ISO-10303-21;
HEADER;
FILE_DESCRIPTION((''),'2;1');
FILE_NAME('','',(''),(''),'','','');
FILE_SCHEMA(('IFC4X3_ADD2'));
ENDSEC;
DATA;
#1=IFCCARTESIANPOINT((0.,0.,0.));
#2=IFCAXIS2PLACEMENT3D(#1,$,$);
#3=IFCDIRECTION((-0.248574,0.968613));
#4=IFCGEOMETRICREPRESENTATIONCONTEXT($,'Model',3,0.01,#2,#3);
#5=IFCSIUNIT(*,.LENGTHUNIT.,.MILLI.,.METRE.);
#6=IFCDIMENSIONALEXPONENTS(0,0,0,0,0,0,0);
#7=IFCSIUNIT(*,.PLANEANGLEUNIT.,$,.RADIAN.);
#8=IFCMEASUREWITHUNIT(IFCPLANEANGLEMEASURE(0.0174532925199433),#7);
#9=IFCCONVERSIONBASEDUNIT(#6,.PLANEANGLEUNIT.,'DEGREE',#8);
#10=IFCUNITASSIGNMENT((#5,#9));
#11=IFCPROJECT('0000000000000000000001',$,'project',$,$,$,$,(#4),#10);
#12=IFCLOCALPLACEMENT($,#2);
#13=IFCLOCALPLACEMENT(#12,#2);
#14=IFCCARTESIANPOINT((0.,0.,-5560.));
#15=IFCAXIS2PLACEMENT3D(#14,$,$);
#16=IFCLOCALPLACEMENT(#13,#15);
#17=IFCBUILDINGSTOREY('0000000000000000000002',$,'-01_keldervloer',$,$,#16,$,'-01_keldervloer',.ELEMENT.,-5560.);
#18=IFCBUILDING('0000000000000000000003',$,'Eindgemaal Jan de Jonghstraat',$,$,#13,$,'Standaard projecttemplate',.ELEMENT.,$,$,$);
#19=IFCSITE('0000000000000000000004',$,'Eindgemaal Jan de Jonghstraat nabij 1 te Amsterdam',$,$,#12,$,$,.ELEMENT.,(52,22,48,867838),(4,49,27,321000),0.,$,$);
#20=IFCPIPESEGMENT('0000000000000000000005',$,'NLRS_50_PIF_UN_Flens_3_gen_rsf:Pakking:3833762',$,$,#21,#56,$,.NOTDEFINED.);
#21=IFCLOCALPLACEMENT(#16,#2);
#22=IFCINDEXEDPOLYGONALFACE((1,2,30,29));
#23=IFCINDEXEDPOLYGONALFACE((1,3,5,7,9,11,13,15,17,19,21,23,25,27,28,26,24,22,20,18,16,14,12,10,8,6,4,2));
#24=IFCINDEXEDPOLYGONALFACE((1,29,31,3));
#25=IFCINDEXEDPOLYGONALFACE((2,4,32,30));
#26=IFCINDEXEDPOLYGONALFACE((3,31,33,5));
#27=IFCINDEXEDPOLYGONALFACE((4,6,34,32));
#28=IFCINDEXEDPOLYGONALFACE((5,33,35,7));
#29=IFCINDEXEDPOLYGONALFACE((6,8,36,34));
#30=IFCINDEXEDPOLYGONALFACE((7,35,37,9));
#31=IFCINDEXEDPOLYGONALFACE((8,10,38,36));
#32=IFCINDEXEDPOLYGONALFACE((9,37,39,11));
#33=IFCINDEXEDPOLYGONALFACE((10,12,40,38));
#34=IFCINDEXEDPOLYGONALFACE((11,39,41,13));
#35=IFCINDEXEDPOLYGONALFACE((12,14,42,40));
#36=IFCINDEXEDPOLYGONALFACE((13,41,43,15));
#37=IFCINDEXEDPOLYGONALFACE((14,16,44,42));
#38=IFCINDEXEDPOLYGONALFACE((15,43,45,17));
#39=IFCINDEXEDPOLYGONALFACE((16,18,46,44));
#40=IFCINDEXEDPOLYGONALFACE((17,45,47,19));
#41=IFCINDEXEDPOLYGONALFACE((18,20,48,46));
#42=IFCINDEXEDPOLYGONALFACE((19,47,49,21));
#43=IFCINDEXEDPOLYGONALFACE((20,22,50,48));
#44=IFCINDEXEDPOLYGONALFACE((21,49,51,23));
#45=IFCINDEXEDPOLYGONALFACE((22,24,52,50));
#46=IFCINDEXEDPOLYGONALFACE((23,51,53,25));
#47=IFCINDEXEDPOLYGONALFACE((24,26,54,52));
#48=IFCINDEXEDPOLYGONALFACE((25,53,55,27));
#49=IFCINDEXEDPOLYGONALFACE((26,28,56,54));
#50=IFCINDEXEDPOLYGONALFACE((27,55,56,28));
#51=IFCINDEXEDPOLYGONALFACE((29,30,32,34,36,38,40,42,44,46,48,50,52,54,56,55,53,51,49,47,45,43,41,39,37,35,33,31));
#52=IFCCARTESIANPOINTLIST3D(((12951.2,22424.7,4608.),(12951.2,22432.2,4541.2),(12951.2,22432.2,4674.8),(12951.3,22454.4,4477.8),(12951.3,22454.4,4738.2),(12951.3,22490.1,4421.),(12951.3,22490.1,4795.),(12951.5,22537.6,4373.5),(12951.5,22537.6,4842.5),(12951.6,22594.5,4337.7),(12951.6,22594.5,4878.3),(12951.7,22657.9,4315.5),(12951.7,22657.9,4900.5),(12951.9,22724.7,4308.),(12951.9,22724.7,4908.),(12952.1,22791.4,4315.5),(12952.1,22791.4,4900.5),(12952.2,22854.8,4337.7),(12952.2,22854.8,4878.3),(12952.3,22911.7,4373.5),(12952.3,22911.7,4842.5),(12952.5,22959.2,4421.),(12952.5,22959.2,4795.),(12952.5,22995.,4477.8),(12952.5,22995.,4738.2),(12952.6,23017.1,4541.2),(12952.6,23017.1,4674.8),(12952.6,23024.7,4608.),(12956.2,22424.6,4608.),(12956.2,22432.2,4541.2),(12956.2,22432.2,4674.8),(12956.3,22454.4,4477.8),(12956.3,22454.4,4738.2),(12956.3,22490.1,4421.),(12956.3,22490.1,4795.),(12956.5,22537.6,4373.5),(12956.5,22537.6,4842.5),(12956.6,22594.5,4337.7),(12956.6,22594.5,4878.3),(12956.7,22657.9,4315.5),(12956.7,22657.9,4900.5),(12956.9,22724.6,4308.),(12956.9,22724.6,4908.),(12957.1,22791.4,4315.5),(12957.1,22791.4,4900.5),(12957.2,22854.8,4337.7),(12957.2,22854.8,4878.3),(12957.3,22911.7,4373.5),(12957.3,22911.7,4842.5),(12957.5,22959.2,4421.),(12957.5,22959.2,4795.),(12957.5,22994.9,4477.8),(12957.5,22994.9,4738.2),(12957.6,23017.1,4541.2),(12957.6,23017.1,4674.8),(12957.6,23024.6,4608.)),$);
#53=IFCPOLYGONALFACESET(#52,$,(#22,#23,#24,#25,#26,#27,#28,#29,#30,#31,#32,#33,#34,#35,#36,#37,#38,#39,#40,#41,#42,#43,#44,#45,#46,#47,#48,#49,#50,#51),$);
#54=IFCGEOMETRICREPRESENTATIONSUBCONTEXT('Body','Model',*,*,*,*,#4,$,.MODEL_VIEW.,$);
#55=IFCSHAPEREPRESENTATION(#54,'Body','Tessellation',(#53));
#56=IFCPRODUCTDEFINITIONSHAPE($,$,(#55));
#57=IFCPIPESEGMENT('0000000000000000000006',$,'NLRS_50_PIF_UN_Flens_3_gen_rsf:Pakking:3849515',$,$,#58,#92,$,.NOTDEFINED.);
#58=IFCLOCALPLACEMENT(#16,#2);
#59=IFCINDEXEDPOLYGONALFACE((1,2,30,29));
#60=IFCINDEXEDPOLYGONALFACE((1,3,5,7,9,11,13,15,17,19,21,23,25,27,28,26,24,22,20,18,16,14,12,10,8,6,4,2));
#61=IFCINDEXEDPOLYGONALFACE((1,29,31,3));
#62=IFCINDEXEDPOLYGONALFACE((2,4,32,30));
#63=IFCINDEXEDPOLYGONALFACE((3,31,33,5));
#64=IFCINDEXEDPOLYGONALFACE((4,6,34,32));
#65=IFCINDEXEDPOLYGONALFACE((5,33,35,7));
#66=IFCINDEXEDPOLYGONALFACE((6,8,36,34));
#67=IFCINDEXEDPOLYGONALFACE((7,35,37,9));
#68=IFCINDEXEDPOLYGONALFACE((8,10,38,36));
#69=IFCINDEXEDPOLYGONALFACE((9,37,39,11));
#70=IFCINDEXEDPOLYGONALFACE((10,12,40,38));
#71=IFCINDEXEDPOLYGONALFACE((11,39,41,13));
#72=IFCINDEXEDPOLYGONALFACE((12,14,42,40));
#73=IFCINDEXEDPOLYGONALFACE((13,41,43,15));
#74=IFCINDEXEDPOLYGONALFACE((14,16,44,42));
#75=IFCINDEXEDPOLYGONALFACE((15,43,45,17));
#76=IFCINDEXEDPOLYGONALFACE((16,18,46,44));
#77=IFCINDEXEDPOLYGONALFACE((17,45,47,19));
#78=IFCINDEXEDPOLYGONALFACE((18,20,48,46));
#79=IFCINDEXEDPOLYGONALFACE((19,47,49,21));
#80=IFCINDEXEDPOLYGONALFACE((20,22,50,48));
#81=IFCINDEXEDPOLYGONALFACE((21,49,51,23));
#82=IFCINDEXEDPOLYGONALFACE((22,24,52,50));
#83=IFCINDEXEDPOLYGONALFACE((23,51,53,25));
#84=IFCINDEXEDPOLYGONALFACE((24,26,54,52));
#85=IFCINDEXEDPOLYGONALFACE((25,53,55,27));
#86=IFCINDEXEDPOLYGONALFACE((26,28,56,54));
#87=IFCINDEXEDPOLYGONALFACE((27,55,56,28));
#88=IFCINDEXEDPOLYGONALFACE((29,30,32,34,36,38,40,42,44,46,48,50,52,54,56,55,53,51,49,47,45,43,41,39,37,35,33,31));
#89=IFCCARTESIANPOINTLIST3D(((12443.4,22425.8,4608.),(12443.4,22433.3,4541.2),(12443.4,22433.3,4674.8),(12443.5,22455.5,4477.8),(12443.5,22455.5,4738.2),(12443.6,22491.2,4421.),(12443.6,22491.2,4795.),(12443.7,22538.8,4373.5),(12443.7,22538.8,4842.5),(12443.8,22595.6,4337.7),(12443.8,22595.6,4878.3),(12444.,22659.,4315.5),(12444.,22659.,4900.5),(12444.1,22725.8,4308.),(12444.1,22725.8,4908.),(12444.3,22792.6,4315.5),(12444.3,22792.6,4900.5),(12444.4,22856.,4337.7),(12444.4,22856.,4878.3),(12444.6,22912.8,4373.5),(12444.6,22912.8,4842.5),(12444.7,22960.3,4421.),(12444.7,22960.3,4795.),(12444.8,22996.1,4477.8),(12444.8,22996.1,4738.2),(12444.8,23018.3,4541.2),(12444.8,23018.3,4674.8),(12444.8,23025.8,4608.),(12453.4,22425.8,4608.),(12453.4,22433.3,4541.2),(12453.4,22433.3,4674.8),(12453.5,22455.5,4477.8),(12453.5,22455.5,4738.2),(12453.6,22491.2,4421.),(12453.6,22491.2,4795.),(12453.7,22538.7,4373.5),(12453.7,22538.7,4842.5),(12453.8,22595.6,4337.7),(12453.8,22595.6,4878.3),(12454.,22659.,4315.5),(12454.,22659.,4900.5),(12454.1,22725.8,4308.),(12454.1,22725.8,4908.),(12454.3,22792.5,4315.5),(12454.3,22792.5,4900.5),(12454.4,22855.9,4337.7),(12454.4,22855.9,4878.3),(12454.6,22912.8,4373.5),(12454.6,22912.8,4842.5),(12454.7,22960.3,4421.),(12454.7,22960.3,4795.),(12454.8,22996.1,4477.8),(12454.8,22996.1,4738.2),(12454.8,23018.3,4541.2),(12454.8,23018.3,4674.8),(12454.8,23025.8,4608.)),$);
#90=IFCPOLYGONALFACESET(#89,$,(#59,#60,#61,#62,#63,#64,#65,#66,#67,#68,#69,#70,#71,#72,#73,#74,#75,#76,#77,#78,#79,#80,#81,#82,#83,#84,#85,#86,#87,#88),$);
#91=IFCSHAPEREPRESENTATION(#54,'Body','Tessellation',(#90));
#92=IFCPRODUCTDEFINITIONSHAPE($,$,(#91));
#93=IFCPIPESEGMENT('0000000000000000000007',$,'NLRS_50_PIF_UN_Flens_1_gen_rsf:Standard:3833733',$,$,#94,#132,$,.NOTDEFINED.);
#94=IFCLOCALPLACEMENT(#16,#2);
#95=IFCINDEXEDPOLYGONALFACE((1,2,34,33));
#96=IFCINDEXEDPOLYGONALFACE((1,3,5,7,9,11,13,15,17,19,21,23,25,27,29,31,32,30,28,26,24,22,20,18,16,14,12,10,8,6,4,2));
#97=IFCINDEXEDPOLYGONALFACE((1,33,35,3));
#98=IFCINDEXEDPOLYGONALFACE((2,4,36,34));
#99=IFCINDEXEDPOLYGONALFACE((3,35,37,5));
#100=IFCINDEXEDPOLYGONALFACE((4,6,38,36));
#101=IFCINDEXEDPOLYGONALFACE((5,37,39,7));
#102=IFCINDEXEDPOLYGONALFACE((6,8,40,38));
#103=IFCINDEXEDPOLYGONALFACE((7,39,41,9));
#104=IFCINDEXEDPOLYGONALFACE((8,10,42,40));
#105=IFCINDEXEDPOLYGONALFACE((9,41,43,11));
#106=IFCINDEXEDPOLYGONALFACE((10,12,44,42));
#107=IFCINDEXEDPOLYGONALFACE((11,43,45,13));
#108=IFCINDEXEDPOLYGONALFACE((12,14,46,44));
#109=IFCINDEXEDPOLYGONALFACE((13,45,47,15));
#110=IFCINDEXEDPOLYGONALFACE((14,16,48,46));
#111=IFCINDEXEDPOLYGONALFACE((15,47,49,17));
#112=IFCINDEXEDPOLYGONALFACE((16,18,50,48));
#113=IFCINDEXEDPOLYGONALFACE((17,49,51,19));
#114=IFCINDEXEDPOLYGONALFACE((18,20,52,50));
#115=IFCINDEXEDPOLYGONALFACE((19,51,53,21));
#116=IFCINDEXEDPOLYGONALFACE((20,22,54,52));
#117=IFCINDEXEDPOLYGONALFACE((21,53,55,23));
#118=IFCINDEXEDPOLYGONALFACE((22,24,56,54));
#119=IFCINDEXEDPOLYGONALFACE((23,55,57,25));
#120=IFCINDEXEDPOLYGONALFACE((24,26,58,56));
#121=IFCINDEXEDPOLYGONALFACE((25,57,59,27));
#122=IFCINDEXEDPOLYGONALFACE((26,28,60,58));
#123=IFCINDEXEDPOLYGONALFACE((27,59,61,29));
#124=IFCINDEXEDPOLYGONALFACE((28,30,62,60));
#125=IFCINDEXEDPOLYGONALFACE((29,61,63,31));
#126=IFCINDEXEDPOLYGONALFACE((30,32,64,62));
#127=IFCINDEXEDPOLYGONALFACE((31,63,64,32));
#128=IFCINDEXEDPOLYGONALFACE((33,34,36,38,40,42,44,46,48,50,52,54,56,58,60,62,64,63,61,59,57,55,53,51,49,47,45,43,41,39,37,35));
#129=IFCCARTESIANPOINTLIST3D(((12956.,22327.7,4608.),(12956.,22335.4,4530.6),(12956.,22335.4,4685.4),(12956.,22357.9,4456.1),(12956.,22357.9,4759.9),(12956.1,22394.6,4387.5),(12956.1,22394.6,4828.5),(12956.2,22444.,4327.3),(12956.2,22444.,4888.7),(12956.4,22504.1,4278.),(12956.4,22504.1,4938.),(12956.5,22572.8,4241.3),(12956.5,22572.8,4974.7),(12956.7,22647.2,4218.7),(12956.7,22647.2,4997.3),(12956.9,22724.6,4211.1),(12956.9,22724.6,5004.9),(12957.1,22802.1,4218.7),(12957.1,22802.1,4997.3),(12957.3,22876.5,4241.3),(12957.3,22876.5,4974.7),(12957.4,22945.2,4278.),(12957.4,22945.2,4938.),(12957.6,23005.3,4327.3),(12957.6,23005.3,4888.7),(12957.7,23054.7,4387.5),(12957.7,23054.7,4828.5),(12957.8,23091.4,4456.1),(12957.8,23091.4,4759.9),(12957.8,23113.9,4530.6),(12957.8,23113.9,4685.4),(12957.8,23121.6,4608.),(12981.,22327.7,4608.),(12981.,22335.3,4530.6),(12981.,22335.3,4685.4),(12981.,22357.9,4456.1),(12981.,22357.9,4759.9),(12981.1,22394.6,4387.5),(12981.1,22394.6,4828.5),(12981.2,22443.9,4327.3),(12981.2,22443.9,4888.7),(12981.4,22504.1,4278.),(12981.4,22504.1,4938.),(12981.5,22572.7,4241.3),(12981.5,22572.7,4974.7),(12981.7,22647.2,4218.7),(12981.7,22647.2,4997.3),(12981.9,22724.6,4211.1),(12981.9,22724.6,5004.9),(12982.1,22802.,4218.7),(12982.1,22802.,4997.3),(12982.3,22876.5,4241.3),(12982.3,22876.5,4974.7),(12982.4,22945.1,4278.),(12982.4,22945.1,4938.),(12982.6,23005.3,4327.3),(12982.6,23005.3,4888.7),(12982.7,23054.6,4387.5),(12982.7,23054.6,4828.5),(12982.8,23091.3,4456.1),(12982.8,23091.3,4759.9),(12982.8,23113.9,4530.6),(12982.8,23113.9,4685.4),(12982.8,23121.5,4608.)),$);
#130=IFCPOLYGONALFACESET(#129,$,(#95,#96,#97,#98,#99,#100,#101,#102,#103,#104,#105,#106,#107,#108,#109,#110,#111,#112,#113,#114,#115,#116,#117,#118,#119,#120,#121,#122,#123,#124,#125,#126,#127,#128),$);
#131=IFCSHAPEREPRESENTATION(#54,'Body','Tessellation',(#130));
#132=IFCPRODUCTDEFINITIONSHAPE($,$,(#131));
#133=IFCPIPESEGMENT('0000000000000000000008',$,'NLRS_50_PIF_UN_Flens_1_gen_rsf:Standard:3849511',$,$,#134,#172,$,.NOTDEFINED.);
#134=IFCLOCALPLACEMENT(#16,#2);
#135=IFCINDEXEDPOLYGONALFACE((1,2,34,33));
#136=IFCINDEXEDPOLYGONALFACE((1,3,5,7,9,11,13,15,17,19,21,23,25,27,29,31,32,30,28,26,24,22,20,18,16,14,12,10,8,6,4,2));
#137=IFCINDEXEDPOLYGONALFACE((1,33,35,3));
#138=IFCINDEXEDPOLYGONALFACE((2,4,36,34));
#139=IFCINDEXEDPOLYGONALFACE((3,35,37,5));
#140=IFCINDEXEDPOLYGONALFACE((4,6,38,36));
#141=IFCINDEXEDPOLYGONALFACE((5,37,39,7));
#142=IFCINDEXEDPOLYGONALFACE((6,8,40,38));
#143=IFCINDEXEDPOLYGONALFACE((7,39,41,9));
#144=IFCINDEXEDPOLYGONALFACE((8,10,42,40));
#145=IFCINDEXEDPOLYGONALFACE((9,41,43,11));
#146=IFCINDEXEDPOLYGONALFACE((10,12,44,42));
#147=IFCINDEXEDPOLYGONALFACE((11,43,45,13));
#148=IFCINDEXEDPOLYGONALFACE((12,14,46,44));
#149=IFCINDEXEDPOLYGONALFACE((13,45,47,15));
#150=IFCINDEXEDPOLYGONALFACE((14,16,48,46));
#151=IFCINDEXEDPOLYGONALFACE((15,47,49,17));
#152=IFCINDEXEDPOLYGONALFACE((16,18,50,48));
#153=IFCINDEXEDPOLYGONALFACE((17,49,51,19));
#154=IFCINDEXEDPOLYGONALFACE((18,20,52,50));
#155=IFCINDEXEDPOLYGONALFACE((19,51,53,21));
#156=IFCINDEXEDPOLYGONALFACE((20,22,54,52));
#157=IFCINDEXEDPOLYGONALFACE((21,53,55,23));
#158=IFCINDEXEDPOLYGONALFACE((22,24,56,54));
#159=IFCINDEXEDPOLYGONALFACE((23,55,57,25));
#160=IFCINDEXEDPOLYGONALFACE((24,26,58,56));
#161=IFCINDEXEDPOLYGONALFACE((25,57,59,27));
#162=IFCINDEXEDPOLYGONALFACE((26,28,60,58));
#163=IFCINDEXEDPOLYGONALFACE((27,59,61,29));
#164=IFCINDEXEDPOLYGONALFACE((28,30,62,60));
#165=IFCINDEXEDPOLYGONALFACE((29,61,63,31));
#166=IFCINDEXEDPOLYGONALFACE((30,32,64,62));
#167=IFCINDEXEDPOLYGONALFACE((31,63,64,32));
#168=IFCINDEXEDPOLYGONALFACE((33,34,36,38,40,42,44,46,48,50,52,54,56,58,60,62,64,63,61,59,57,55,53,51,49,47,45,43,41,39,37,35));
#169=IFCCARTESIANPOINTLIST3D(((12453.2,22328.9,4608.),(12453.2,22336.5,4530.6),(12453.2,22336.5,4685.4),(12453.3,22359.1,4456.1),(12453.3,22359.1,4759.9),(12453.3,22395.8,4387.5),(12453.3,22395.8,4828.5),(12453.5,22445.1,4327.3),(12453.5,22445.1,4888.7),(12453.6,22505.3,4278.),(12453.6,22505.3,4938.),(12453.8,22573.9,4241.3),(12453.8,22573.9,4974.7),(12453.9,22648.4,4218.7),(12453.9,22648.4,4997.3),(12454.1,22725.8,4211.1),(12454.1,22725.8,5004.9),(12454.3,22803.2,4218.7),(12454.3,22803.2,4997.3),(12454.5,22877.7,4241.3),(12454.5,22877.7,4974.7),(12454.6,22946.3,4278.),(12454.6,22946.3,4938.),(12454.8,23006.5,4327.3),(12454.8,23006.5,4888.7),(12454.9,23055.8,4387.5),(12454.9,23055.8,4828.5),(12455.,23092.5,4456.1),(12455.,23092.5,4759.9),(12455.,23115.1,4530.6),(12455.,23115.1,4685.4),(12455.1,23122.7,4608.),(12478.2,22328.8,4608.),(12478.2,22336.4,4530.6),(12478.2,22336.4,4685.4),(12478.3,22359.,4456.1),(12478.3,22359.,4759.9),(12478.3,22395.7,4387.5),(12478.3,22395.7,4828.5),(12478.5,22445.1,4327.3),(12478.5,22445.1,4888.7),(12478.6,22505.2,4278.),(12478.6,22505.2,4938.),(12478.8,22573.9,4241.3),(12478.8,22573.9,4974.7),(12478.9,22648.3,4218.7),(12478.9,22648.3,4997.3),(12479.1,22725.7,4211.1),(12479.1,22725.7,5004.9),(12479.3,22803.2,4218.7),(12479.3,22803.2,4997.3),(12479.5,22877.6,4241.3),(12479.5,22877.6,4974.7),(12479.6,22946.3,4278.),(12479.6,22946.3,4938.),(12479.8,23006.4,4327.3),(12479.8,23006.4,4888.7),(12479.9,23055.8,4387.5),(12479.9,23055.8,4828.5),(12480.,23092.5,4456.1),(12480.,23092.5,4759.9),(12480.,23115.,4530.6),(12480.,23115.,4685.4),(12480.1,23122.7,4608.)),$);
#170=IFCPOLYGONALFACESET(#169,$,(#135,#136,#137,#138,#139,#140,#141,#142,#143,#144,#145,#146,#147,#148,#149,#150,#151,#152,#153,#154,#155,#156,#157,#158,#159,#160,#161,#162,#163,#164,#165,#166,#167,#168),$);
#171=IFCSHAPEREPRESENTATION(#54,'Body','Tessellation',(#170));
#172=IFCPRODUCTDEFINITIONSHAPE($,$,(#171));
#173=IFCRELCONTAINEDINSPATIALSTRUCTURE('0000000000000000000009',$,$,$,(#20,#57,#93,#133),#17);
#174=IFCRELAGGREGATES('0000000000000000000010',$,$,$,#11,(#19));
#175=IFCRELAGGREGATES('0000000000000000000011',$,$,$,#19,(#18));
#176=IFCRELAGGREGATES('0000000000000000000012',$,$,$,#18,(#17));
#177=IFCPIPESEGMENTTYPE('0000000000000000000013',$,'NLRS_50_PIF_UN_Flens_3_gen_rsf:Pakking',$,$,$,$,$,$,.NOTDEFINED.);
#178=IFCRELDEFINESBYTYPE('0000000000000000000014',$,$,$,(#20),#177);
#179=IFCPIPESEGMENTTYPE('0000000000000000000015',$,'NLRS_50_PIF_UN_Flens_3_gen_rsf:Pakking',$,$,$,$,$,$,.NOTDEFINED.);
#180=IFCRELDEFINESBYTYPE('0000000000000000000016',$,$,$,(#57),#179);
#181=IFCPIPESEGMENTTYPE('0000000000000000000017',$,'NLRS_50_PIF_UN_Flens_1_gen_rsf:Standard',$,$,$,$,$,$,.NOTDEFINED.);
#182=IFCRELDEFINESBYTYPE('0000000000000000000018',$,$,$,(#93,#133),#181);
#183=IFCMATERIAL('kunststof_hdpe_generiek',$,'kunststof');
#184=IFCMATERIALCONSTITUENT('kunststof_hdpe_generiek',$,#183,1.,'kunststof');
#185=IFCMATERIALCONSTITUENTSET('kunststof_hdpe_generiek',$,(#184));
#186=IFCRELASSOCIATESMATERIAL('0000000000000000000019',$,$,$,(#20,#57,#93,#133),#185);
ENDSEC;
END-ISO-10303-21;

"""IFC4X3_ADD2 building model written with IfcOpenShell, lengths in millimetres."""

from ifc_helpers import new_model, entity, si_unit, converted_unit, direction, frame, frame_2d, origin, place, context, subcontext, project, spatial, circle, extrude, source, transform, mapped, material, constituent, constituent_set, type_object, type_shapes, element, save


model = new_model("IFC4X3_ADD2")

# Units and contexts
model_context = context("Model", 3, precision=0.01, world=origin(), true_north=direction((-0.248574, 0.968613)))
body_context = subcontext(model_context, "Body", "Model", "MODEL_VIEW")
ifc_project = project(units=[si_unit("LENGTHUNIT", "METRE", prefix="MILLI"), converted_unit("PLANEANGLEUNIT", "DEGREE", entity("IfcPlaneAngleMeasure", 0.0174532925199433), si_unit("PLANEANGLEUNIT", "RADIAN"), dimensions=[0, 0, 0, 0, 0, 0, 0])], contexts=[model_context])

# Site, building, storey
site_placement = place(None, origin())
site = spatial("IfcSite", under=ifc_project, at=site_placement, Name="Eindgemaal Jan de Jonghstraat nabij 1 te Amsterdam", CompositionType="ELEMENT", RefLatitude=(52, 22, 48, 867838), RefLongitude=(4, 49, 27, 321000), RefElevation=0.0)
building_placement = place(site_placement, origin())
building = spatial("IfcBuilding", under=site, at=building_placement, Name="Eindgemaal Jan de Jonghstraat", LongName="Standaard projecttemplate", CompositionType="ELEMENT")
storey_placement = place(building_placement, frame((0.0, 0.0, -5560.0)))
storey = spatial("IfcBuildingStorey", under=building, at=storey_placement, Name="-01_keldervloer", LongName="-01_keldervloer", CompositionType="ELEMENT", Elevation=-5560.0)

# Pipe segments
ifc_material_1 = material(Name="kunststof_hdpe_generiek", Category="kunststof")
ifc_constituent_1 = constituent(ifc_material_1, Name="kunststof_hdpe_generiek", Category="kunststof", fraction=1.0)
ifc_constituent_set_1 = constituent_set(constituents=[ifc_constituent_1], Name="kunststof_hdpe_generiek")
pipe_segment_type_1 = type_object("IfcPipeSegmentType", Name="NLRS_50_PIF_UN_Flens_3_gen_rsf:Pakking", PredefinedType="NOTDEFINED")
shared_shape_1 = source(origin(), body_context, "Body", "SweptSolid", [
    extrude(circle(Radius=300.0, at=frame_2d((0.0, 0.0), x_axis=(1.0, 0.0))), frame((0.0, 0.0, 0.0), z_axis=(0.0, 0.0, 1.0), x_axis=(0.0, -1.0, 0.0)), (0.0, 0.0, 1.0), 5.0),
])
type_shapes(pipe_segment_type_1, [shared_shape_1])
pipe_segment_1_placement = place(storey_placement, frame((12951.9, 22724.7, 4608.0), z_axis=(0.999997, -0.002375, 0.0), x_axis=(0.0, 0.0, -1.0)))
element("IfcPipeSegment", 1, at=pipe_segment_1_placement, inside=storey, type_object=pipe_segment_type_1, material=ifc_constituent_set_1, Name="NLRS_50_PIF_UN_Flens_3_gen_rsf:Pakking:3833762", PredefinedType="NOTDEFINED", context=body_context, shape_type="MappedRepresentation", body=[
    mapped(shared_shape_1, transform((0.0, 0.0, 0.0), scale=1.0)),
])
pipe_segment_type_2 = type_object("IfcPipeSegmentType", Name="NLRS_50_PIF_UN_Flens_3_gen_rsf:Pakking", PredefinedType="NOTDEFINED")
shared_shape_2 = source(origin(), body_context, "Body", "SweptSolid", [
    extrude(circle(Radius=300.0, at=frame_2d((0.0, 0.0), x_axis=(1.0, 0.0))), frame((0.0, 0.0, 0.0), z_axis=(0.0, 0.0, 1.0), x_axis=(0.0, -1.0, 0.0)), (0.0, 0.0, 1.0), 10.0),
])
type_shapes(pipe_segment_type_2, [shared_shape_2])
pipe_segment_2_placement = place(storey_placement, frame((12454.1, 22725.8, 4608.0), z_axis=(-0.999997, 0.002363, 0.0), x_axis=(0.0, 0.0, -1.0)))
element("IfcPipeSegment", 2, at=pipe_segment_2_placement, inside=storey, type_object=pipe_segment_type_2, material=ifc_constituent_set_1, Name="NLRS_50_PIF_UN_Flens_3_gen_rsf:Pakking:3849515", PredefinedType="NOTDEFINED", context=body_context, shape_type="MappedRepresentation", body=[
    mapped(shared_shape_2, transform((0.0, 0.0, 0.0), scale=1.0)),
])
pipe_segment_type_3 = type_object("IfcPipeSegmentType", Name="NLRS_50_PIF_UN_Flens_1_gen_rsf:Standard", PredefinedType="NOTDEFINED")
shared_shape_3 = source(origin(), body_context, "Body", "SweptSolid", [
    extrude(circle(Radius=396.9, at=frame_2d((0.0, 0.0), x_axis=(1.0, 0.0))), frame((-12.5, 0.0, 0.0), z_axis=(1.0, 0.0, 0.0), x_axis=(0.0, 1.0, 0.0)), (0.0, 0.0, 1.0), 25.0),
])
type_shapes(pipe_segment_type_3, [shared_shape_3])
for number, where, z_axis, x_axis, name in (
    (3, (12969.4, 22724.6, 4608.0), (0.0, 0.0, -1.0), (0.999997, -0.002375, 0.0), "NLRS_50_PIF_UN_Flens_1_gen_rsf:Standard:3833733"),
    (4, (12466.6, 22725.8, 4608.0), (0.0, 0.0, -1.0), (0.999997, -0.002363, 0.0), "NLRS_50_PIF_UN_Flens_1_gen_rsf:Standard:3849511"),
):
    element("IfcPipeSegment", number, at=place(storey_placement, frame(where, z_axis=z_axis, x_axis=x_axis)), inside=storey, type_object=pipe_segment_type_3, material=ifc_constituent_set_1, Name=name, PredefinedType="NOTDEFINED", context=body_context, shape_type="MappedRepresentation", body=[
        mapped(shared_shape_3, transform((0.0, 0.0, 0.0), scale=1.0)),
    ])

save(model, "model.ifc")
